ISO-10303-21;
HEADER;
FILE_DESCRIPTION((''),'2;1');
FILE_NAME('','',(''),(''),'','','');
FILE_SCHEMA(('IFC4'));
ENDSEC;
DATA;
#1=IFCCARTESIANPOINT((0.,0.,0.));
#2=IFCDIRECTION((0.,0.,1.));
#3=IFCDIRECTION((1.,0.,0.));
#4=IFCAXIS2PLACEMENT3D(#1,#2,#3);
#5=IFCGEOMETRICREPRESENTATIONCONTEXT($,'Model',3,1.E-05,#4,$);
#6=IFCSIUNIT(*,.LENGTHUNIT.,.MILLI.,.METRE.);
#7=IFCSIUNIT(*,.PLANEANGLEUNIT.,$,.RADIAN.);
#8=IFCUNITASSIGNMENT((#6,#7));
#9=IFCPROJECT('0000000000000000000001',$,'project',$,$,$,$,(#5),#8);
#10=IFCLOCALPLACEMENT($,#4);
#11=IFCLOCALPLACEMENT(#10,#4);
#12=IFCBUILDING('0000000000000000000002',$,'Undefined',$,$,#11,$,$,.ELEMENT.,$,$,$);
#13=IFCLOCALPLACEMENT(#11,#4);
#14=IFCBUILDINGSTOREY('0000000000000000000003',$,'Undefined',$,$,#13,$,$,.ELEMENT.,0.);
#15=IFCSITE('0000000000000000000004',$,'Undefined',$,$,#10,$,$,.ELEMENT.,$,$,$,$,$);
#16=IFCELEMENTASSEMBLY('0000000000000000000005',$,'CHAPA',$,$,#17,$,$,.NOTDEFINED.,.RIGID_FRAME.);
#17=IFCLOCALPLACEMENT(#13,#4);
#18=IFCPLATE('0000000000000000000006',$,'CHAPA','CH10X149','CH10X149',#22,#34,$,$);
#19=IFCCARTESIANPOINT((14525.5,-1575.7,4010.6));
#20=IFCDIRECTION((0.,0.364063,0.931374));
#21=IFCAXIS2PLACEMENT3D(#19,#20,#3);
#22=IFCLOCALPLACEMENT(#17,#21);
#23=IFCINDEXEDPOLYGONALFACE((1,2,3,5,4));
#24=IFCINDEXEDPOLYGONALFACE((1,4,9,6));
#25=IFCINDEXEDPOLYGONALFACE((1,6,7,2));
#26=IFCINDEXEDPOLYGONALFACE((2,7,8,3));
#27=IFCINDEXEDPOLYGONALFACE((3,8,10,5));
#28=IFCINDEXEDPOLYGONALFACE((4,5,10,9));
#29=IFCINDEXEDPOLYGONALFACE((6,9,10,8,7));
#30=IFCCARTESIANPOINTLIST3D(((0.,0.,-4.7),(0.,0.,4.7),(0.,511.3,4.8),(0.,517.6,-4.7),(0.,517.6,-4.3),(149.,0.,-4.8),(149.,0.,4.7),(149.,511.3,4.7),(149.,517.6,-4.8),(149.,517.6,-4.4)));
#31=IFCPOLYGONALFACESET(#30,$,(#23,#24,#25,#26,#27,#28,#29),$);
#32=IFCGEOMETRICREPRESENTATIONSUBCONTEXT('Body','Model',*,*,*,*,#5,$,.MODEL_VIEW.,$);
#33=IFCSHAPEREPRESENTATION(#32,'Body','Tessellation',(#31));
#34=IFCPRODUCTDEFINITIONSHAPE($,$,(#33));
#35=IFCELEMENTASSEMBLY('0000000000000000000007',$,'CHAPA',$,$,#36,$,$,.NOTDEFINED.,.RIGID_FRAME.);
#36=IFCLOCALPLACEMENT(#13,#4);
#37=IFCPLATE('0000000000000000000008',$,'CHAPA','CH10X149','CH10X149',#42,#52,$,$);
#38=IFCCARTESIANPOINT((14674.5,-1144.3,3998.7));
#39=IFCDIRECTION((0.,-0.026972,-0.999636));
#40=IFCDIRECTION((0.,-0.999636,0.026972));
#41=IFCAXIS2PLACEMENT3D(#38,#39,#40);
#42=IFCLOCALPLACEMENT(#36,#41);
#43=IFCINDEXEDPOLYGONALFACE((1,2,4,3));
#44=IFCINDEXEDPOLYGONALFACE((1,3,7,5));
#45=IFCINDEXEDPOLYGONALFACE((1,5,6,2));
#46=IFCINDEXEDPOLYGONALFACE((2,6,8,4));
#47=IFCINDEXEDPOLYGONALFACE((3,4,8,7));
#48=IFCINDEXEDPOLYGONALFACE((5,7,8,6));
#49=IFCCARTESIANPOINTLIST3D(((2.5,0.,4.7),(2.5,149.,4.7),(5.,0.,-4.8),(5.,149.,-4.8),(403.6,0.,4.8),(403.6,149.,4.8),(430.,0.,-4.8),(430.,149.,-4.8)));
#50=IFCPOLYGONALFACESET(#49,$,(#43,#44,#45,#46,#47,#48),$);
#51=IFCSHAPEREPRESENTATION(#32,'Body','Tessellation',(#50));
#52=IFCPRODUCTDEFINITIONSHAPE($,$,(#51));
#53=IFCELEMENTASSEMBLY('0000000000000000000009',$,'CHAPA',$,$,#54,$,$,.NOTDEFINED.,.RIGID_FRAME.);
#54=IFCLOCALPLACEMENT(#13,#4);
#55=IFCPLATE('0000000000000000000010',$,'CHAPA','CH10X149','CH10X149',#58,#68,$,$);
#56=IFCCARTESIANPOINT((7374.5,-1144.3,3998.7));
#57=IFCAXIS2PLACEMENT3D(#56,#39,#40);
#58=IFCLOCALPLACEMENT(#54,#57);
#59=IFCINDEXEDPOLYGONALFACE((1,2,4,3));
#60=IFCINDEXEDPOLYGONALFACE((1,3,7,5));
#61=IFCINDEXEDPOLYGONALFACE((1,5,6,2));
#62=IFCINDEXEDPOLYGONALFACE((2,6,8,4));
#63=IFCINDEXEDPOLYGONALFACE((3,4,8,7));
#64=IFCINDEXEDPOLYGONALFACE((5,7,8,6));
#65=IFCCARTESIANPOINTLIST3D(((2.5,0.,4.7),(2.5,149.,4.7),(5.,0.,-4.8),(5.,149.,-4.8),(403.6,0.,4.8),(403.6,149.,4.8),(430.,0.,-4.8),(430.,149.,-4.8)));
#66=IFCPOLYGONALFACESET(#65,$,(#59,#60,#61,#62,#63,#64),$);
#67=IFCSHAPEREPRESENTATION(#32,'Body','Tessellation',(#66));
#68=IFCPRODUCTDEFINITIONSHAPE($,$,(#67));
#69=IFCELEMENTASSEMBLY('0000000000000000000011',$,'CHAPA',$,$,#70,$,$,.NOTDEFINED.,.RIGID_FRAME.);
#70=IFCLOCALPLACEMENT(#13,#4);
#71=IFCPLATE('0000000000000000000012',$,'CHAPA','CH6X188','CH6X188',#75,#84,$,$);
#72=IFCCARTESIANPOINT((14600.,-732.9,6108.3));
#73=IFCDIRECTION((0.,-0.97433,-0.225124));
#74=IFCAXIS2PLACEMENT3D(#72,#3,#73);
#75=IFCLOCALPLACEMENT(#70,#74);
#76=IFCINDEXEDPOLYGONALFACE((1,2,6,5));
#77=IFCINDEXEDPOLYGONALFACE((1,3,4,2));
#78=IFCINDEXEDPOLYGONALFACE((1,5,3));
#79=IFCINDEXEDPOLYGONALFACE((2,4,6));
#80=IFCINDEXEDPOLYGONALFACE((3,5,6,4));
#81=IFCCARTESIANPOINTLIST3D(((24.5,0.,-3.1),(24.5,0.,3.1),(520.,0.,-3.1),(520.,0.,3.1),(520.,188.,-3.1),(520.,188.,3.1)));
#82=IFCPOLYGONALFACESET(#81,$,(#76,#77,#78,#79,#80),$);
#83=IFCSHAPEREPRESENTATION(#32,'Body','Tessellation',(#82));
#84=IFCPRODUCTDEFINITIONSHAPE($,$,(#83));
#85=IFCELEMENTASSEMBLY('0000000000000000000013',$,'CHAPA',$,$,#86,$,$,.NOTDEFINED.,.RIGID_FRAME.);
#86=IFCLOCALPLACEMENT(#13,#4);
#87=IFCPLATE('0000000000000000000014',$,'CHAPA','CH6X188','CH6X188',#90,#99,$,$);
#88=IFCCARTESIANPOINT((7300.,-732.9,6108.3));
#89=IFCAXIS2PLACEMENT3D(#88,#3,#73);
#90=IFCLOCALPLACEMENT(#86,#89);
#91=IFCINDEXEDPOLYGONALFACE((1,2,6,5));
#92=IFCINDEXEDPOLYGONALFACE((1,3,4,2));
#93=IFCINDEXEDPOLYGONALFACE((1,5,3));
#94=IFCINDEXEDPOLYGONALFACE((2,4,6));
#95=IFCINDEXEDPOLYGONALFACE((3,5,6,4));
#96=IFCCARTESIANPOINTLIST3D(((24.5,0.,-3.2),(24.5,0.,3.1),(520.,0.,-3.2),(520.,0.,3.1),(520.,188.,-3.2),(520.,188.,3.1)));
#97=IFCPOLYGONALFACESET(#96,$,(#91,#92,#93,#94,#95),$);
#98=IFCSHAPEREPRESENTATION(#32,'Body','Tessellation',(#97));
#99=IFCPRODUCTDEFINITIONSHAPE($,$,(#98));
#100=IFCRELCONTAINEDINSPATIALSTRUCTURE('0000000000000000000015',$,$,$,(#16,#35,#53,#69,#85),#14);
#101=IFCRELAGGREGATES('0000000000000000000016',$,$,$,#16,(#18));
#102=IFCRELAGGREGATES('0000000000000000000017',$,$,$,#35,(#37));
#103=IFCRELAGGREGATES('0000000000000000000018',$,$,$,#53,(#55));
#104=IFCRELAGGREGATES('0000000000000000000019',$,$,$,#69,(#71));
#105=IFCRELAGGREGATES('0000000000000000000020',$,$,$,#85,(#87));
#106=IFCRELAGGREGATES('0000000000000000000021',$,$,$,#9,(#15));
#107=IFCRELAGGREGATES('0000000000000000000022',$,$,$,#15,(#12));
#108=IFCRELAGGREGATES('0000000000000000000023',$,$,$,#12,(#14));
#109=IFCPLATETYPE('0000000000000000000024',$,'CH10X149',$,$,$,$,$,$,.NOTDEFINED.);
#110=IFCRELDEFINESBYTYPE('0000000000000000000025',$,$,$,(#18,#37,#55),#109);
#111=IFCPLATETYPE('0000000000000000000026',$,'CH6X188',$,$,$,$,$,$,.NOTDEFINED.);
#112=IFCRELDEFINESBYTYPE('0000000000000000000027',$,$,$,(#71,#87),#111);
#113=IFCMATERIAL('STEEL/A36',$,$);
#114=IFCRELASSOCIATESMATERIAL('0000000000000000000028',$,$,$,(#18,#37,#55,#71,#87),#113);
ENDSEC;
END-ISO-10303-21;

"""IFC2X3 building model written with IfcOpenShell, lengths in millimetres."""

from ifc_helpers import new_model, si_unit, frame, origin_with_axes, place, context, subcontext, project, spatial, polyline, outline, extrude, clip, halfspace, material, type_object, element, aggregate, save


model = new_model("IFC2X3")

# Units and contexts
model_context = context("Model", 3, precision=1e-05, world=origin_with_axes())
body_context = subcontext(model_context, "Body", "Model", "MODEL_VIEW")
ifc_project = project(units=[si_unit("LENGTHUNIT", "METRE", prefix="MILLI"), si_unit("PLANEANGLEUNIT", "RADIAN")], contexts=[model_context])

# Site, building, storey
site_placement = place(None, origin_with_axes())
site = spatial("IfcSite", under=ifc_project, at=site_placement, Name="Undefined", CompositionType="ELEMENT")
building_placement = place(site_placement, origin_with_axes())
building = spatial("IfcBuilding", under=site, at=building_placement, Name="Undefined", CompositionType="ELEMENT")
storey_placement = place(building_placement, origin_with_axes())
storey = spatial("IfcBuildingStorey", under=building, at=storey_placement, Name="Undefined", CompositionType="ELEMENT", Elevation=0.0)

# Shared definitions
ifc_material_1 = material(Name="STEEL/A36")

# Element assemblies, plates
assembly_1_placement = place(storey_placement, origin_with_axes())
assembly_1 = element("IfcElementAssembly", 1, at=assembly_1_placement, inside=storey, Name="CHAPA", AssemblyPlace="NOTDEFINED", PredefinedType="RIGID_FRAME")
plate_type_1 = type_object("IfcPlateType", Name="CH10X149", PredefinedType="NOTDEFINED")
plate_1_placement = place(assembly_1_placement, frame((14525.5, -1575.7, 4010.6), z_axis=(0.0, 0.364063, 0.931374), x_axis=(1.0, 0.0, 0.0)))
plate_1 = element("IfcPlate", 2, at=plate_1_placement, type_object=plate_type_1, material=ifc_material_1, Name="CHAPA", Description="CH10X149", ObjectType="CH10X149", context=body_context, shape_type="Clipping", body=[
    clip(extrude(outline(polyline([(0.0, 0.0), (149.0, 0.0), (149.0, 517.6), (0.0, 517.6), (0.0, 0.0)])), frame((0.0, 0.0, -4.8), z_axis=(0.0, 0.0, 1.0), x_axis=(1.0, 0.0, 0.0)), (0.0, 0.0, 1.0), 9.5), halfspace(frame((149.0, 517.9, -4.7), z_axis=(0.0, 0.821204, 0.570634), x_axis=(0.0, -0.570634, 0.821204)), False)),
])
aggregate(assembly_1, [plate_1])
assembly_2_placement = place(storey_placement, origin_with_axes())
assembly_2 = element("IfcElementAssembly", 3, at=assembly_2_placement, inside=storey, Name="CHAPA", AssemblyPlace="NOTDEFINED", PredefinedType="RIGID_FRAME")
plate_2_placement = place(assembly_2_placement, frame((14674.5, -1144.3, 3998.7), z_axis=(0.0, -0.026972, -0.999636), x_axis=(0.0, -0.999636, 0.026972)))
plate_2 = element("IfcPlate", 4, at=plate_2_placement, type_object=plate_type_1, material=ifc_material_1, Name="CHAPA", Description="CH10X149", ObjectType="CH10X149", context=body_context, shape_type="Clipping", body=[
    clip(clip(extrude(outline(polyline([(0.0, 0.0), (430.0, 0.0), (430.0, 149.0), (0.0, 149.0), (0.0, 0.0)])), frame((0.0, 0.0, -4.8), z_axis=(0.0, 0.0, 1.0), x_axis=(1.0, 0.0, 0.0)), (0.0, 0.0, 1.0), 9.5), halfspace(frame((403.6, -500.0, 4.7), z_axis=(0.33881, 0.0, 0.940855), x_axis=(0.0, 1.0, 0.0)), False)), halfspace(frame((5.0, -500.0, -4.8), z_axis=(-0.965989, 0.0, -0.258583), x_axis=(0.0, 1.0, 0.0)), False)),
])
aggregate(assembly_2, [plate_2])
assembly_3_placement = place(storey_placement, origin_with_axes())
assembly_3 = element("IfcElementAssembly", 5, at=assembly_3_placement, inside=storey, Name="CHAPA", AssemblyPlace="NOTDEFINED", PredefinedType="RIGID_FRAME")
plate_3_placement = place(assembly_3_placement, frame((7374.5, -1144.3, 3998.7), z_axis=(0.0, -0.026972, -0.999636), x_axis=(0.0, -0.999636, 0.026972)))
plate_3 = element("IfcPlate", 6, at=plate_3_placement, type_object=plate_type_1, material=ifc_material_1, Name="CHAPA", Description="CH10X149", ObjectType="CH10X149", context=body_context, shape_type="Clipping", body=[
    clip(clip(extrude(outline(polyline([(0.0, 0.0), (430.0, 0.0), (430.0, 149.0), (0.0, 149.0), (0.0, 0.0)])), frame((0.0, 0.0, -4.8), z_axis=(0.0, 0.0, 1.0), x_axis=(1.0, 0.0, 0.0)), (0.0, 0.0, 1.0), 9.5), halfspace(frame((403.6, -500.0, 4.7), z_axis=(0.33881, 0.0, 0.940855), x_axis=(0.0, 1.0, 0.0)), False)), halfspace(frame((5.0, -500.0, -4.8), z_axis=(-0.965989, 0.0, -0.258583), x_axis=(0.0, 1.0, 0.0)), False)),
])
aggregate(assembly_3, [plate_3])
assembly_4_placement = place(storey_placement, origin_with_axes())
assembly_4 = element("IfcElementAssembly", 7, at=assembly_4_placement, inside=storey, Name="CHAPA", AssemblyPlace="NOTDEFINED", PredefinedType="RIGID_FRAME")
plate_type_2 = type_object("IfcPlateType", Name="CH6X188", PredefinedType="NOTDEFINED")
plate_4_placement = place(assembly_4_placement, frame((14600.0, -732.9, 6108.3), z_axis=(1.0, 0.0, 0.0), x_axis=(0.0, -0.97433, -0.225124)))
plate_4 = element("IfcPlate", 8, at=plate_4_placement, type_object=plate_type_2, material=ifc_material_1, Name="CHAPA", Description="CH6X188", ObjectType="CH6X188", context=body_context, shape_type="Clipping", body=[
    clip(extrude(outline(polyline([(0.0, 0.0), (520.0, 0.0), (520.0, 191.6), (0.0, 0.0)])), frame((0.0, 0.0, -3.1), z_axis=(0.0, 0.0, 1.0), x_axis=(1.0, 0.0, 0.0)), (0.0, 0.0, 1.0), 6.3), halfspace(frame((1342.2, 500.0, 3.2), z_axis=(-0.354778, 0.934951, 0.0), x_axis=(-0.934951, -0.354778, 0.0)), False)),
])
aggregate(assembly_4, [plate_4])
assembly_5_placement = place(storey_placement, origin_with_axes())
assembly_5 = element("IfcElementAssembly", 9, at=assembly_5_placement, inside=storey, Name="CHAPA", AssemblyPlace="NOTDEFINED", PredefinedType="RIGID_FRAME")
plate_5_placement = place(assembly_5_placement, frame((7300.0, -732.9, 6108.3), z_axis=(1.0, 0.0, 0.0), x_axis=(0.0, -0.97433, -0.225124)))
plate_5 = element("IfcPlate", 10, at=plate_5_placement, type_object=plate_type_2, material=ifc_material_1, Name="CHAPA", Description="CH6X188", ObjectType="CH6X188", context=body_context, shape_type="Clipping", body=[
    clip(extrude(outline(polyline([(0.0, 0.0), (520.0, 0.0), (520.0, 191.6), (0.0, 0.0)])), frame((0.0, 0.0, -3.1), z_axis=(0.0, 0.0, 1.0), x_axis=(1.0, 0.0, 0.0)), (0.0, 0.0, 1.0), 6.3), halfspace(frame((1342.2, 500.0, 3.2), z_axis=(-0.354778, 0.934951, 0.0), x_axis=(-0.934951, -0.354778, 0.0)), False)),
])
aggregate(assembly_5, [plate_5])

save(model, "model.ifc")
